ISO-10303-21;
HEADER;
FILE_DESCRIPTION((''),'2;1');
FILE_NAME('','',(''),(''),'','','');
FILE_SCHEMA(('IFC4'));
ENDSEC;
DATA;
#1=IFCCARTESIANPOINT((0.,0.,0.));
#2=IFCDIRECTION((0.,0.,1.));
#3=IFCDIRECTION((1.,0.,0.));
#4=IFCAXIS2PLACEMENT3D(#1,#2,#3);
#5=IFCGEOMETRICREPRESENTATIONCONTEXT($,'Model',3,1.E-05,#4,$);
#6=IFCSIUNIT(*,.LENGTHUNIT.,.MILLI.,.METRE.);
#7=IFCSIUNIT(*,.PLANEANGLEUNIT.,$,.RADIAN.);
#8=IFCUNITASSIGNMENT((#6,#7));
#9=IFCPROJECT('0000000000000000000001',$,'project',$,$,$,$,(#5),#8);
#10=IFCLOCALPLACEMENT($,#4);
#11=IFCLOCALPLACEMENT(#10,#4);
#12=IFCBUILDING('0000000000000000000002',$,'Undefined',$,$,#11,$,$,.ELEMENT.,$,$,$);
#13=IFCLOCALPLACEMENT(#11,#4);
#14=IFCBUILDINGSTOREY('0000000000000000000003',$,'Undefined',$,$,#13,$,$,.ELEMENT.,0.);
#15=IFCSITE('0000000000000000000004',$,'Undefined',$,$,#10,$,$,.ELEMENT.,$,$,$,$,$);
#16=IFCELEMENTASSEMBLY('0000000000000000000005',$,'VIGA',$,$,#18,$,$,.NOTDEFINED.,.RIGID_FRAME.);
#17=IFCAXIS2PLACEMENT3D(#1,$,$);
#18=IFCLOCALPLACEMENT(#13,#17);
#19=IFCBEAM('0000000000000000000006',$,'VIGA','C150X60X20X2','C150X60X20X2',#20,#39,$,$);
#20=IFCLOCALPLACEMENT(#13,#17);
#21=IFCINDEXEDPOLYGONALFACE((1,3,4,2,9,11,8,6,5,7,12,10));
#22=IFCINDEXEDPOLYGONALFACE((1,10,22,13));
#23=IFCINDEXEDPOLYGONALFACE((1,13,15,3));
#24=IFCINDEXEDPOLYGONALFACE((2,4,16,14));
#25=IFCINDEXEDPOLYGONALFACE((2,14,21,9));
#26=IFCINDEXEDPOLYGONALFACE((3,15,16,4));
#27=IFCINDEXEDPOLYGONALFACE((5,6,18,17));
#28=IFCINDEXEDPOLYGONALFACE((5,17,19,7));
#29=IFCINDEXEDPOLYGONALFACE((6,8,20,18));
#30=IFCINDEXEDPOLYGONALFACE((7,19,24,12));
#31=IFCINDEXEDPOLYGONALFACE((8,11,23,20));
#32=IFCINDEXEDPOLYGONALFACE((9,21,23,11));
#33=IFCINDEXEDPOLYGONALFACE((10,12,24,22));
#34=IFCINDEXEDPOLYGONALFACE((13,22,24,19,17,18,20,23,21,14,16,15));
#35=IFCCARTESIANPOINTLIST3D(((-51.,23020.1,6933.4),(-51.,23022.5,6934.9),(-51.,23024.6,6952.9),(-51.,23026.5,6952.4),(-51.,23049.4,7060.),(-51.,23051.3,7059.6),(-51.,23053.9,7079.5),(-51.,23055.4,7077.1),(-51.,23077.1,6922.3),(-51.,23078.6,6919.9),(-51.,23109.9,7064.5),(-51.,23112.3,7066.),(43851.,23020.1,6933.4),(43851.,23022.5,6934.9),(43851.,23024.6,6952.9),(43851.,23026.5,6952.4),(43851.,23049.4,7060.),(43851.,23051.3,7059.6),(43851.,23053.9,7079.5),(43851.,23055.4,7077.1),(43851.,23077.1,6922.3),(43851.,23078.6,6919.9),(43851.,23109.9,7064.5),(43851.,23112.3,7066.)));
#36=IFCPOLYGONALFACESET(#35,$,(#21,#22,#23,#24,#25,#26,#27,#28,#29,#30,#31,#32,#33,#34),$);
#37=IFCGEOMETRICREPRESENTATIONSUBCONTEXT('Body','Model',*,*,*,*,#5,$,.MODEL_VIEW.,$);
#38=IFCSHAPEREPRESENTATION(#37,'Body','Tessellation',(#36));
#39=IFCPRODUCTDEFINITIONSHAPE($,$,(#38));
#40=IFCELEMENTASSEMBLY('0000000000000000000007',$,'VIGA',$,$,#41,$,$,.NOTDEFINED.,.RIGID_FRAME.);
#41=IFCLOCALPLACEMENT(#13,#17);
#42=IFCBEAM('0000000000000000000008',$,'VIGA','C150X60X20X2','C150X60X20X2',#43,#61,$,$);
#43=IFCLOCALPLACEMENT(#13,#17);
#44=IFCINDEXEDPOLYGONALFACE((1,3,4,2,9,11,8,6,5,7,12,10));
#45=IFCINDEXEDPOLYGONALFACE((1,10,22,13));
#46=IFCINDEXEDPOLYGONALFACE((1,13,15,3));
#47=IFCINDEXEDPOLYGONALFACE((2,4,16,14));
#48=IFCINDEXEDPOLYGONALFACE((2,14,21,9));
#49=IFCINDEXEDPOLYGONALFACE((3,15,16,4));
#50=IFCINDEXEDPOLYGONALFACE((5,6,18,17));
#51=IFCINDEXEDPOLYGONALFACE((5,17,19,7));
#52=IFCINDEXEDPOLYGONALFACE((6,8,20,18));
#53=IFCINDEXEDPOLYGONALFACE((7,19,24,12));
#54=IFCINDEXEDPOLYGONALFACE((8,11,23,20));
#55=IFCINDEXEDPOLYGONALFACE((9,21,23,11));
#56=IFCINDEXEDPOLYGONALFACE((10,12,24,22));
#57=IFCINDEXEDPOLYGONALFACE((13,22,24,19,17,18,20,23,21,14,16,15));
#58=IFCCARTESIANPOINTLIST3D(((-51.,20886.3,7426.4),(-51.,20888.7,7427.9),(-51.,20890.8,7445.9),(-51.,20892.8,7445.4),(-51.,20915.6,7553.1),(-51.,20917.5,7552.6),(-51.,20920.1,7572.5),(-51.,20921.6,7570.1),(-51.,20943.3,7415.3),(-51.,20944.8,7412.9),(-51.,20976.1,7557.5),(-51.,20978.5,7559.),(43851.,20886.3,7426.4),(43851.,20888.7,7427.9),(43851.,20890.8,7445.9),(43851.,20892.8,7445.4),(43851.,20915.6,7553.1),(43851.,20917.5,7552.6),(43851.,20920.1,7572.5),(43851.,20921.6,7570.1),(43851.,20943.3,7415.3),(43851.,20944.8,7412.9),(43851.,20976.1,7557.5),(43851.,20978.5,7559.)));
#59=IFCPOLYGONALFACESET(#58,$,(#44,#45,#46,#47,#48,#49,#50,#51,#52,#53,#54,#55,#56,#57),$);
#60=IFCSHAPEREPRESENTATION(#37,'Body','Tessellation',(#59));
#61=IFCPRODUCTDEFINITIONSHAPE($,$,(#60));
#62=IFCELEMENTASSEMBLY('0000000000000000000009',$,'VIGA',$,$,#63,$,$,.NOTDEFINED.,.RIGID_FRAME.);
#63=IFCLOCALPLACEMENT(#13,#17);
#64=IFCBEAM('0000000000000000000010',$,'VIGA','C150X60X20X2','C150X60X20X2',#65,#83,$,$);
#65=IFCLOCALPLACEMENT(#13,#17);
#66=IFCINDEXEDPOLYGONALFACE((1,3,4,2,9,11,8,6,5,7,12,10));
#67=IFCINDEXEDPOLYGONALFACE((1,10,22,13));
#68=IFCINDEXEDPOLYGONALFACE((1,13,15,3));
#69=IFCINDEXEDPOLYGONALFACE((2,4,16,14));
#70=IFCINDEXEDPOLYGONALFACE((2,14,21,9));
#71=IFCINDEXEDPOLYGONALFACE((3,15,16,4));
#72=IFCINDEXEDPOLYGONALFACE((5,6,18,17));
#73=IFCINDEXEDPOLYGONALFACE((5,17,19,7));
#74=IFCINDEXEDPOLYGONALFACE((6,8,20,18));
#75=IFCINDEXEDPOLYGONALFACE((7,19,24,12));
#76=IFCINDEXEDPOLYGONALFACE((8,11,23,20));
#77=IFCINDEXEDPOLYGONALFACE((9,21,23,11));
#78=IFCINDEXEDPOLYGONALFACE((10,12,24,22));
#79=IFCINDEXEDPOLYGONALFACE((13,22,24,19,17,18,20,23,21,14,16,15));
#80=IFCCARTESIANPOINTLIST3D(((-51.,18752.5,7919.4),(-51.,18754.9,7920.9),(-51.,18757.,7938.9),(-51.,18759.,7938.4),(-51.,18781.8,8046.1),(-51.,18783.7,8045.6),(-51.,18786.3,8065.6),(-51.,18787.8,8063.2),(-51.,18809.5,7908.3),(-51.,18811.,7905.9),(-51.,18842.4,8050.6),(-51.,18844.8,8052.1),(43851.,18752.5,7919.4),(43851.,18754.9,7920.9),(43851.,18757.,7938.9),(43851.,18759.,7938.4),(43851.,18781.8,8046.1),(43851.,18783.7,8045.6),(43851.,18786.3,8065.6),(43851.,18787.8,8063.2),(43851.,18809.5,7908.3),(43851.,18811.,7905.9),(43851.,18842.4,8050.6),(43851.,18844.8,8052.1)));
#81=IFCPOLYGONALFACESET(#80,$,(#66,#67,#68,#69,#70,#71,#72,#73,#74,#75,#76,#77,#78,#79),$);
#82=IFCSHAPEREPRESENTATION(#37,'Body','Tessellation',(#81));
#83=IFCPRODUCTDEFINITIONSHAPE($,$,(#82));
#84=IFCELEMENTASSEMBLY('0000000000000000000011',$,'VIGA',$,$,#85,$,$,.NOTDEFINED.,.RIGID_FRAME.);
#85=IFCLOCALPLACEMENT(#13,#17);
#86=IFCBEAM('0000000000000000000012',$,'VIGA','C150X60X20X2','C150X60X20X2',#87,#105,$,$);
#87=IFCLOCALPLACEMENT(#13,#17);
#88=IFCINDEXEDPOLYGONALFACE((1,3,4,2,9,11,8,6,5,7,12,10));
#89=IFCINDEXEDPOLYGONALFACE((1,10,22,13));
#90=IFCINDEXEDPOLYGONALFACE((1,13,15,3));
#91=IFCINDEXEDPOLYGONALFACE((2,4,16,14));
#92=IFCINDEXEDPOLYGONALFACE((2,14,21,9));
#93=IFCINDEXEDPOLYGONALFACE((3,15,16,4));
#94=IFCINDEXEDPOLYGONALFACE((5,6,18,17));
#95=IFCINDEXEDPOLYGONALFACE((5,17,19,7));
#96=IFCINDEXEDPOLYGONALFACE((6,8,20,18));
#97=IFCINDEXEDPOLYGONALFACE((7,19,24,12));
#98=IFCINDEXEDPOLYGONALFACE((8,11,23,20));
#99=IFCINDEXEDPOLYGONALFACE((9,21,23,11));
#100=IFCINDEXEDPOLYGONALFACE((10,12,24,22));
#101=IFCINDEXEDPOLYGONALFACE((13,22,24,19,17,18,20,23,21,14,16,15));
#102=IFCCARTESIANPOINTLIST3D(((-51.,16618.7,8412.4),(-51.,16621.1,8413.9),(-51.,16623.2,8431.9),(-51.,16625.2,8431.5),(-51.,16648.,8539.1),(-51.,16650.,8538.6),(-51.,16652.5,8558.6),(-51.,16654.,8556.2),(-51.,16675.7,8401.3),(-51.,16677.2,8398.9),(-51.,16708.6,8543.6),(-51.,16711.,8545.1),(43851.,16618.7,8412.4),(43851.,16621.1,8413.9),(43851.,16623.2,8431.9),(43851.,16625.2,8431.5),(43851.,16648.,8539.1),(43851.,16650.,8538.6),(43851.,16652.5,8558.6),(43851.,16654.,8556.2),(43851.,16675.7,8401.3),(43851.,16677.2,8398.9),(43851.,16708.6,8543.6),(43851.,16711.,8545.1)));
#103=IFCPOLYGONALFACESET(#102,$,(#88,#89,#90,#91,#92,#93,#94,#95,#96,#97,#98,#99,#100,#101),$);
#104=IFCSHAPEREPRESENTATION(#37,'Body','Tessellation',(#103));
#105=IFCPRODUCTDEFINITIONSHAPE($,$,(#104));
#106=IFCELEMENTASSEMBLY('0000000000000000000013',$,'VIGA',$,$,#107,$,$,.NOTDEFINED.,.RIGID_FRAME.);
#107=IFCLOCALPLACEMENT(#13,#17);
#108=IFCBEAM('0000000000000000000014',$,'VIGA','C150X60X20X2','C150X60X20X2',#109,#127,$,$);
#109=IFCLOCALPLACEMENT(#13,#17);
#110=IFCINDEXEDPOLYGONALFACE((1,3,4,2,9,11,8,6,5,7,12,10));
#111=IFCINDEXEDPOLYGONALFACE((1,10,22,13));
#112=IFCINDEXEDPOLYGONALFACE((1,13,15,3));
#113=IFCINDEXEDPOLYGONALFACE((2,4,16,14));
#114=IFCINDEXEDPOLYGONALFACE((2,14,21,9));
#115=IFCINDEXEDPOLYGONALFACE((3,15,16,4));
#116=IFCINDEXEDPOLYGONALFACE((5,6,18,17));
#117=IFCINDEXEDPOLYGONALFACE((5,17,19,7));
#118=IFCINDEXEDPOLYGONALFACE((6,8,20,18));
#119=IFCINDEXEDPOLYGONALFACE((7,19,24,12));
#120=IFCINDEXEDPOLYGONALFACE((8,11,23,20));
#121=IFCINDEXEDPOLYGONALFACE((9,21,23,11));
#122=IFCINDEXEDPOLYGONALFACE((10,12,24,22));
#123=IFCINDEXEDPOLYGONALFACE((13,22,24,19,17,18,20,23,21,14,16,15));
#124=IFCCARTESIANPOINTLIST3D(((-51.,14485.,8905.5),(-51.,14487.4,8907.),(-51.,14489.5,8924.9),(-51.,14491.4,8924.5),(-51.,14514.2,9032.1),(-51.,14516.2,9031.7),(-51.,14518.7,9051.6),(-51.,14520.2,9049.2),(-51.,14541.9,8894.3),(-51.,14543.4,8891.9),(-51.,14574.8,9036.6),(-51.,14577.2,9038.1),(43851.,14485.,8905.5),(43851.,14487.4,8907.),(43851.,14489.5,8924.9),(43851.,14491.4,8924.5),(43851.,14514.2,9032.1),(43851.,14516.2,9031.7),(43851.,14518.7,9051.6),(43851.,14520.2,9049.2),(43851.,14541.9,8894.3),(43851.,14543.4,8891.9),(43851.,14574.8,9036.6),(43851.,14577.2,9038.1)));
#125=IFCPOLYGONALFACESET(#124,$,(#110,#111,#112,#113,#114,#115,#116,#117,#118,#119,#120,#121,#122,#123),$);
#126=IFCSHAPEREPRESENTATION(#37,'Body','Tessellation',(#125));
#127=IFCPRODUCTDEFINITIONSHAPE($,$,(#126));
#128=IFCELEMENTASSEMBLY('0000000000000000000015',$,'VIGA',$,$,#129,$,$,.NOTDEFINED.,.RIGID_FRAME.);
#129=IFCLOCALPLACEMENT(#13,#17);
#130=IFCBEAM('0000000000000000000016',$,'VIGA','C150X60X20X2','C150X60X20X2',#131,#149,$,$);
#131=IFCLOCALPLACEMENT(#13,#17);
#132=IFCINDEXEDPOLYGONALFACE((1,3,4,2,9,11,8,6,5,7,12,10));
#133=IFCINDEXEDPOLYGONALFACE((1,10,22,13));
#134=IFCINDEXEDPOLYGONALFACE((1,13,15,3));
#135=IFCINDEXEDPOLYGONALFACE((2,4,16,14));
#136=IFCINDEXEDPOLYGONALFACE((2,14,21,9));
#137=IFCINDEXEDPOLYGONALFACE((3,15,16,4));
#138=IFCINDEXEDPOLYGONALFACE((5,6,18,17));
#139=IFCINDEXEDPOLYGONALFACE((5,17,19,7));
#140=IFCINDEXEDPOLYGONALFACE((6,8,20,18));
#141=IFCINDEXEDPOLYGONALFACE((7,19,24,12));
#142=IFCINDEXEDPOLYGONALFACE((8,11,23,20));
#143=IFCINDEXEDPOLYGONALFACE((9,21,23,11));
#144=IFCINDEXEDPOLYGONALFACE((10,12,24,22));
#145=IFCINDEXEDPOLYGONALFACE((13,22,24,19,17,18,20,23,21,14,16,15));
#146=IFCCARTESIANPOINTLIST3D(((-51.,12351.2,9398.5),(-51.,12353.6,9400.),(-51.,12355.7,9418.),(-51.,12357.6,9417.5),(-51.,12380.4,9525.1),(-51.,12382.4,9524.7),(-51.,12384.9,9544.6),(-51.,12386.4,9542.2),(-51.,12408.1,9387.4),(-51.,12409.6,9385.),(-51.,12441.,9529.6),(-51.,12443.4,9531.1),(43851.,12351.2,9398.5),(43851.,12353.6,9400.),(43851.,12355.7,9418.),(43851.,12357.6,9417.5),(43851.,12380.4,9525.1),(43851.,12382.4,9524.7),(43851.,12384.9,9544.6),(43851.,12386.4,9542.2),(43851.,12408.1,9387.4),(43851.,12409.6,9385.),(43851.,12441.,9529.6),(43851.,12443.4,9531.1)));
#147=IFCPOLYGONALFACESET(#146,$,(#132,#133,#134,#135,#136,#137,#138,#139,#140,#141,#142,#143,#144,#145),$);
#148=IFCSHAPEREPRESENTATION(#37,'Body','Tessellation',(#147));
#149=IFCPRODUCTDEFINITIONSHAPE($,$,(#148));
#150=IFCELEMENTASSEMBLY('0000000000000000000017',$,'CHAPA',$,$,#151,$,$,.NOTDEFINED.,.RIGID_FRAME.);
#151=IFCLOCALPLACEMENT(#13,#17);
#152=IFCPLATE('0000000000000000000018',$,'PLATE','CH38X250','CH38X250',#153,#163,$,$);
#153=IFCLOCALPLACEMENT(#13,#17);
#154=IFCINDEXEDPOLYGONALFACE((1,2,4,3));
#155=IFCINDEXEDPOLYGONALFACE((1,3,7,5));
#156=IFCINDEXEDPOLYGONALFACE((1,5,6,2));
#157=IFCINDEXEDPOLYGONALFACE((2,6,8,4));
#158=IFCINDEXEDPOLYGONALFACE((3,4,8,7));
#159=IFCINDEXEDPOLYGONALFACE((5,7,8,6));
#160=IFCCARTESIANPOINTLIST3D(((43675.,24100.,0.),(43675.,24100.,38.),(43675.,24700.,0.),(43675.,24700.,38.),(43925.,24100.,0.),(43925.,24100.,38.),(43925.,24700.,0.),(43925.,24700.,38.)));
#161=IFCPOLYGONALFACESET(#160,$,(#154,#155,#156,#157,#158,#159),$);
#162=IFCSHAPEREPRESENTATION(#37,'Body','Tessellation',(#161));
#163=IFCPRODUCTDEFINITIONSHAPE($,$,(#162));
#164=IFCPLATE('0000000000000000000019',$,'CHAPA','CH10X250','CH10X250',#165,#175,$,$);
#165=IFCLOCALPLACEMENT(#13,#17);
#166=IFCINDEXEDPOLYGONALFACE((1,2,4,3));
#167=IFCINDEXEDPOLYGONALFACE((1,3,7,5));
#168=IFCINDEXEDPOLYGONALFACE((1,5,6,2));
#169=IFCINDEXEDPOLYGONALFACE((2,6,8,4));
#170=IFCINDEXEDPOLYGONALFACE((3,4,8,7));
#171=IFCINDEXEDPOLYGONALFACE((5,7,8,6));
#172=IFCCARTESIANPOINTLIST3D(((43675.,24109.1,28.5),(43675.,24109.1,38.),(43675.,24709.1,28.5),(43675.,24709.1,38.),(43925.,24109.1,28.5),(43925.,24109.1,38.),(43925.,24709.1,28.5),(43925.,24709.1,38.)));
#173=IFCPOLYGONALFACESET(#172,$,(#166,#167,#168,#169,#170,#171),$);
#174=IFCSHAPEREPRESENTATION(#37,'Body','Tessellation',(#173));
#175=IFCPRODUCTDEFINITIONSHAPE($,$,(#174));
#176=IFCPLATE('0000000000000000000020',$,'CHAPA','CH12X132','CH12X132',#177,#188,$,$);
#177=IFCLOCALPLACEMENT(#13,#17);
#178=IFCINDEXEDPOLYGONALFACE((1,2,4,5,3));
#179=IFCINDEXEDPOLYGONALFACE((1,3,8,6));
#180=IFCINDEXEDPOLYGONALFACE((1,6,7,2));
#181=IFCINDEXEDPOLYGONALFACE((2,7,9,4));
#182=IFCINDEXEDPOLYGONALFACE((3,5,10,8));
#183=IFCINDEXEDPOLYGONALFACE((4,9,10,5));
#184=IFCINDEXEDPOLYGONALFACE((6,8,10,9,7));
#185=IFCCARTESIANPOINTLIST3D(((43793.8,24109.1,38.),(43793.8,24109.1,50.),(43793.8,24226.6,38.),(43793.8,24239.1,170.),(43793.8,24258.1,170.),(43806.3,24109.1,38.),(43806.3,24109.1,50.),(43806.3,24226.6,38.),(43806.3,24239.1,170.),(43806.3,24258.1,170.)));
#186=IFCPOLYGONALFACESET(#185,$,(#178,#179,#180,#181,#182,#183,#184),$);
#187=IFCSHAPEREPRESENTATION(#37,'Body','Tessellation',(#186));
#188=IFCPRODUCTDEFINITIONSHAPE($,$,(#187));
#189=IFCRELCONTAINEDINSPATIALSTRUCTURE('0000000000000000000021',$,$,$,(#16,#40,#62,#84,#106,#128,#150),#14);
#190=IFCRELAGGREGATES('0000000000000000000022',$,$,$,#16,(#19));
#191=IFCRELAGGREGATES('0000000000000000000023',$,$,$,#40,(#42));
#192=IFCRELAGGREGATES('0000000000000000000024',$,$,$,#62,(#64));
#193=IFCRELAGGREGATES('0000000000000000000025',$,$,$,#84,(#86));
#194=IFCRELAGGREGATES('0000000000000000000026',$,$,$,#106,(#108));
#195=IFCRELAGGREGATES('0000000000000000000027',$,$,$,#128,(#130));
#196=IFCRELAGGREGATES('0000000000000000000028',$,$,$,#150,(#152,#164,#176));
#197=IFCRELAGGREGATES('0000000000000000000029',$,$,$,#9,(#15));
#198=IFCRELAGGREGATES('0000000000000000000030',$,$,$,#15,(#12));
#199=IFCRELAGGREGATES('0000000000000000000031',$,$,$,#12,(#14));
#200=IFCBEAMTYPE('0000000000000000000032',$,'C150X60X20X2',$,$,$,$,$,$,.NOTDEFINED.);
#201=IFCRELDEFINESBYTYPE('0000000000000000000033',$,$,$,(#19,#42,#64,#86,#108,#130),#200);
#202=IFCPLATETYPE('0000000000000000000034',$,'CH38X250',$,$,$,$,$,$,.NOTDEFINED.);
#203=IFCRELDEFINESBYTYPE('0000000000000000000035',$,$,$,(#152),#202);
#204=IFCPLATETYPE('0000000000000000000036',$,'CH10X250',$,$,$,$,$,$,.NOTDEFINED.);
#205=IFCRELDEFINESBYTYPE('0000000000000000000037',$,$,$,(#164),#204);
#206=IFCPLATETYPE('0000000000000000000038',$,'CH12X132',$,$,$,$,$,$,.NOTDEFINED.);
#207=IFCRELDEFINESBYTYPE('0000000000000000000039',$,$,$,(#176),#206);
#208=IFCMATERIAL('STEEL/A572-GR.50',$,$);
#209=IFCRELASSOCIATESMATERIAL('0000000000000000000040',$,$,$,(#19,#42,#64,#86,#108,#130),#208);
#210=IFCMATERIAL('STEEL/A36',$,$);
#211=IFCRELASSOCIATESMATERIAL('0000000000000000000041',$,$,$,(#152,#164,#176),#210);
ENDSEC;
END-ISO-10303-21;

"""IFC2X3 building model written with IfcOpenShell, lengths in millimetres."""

from ifc_helpers import new_model, si_unit, frame, origin_with_axes, origin_2d_with_axis, place, context, subcontext, project, spatial, polyline, c_section, outline, extrude, material, type_object, element, aggregate, save


model = new_model("IFC2X3")

# Units and contexts
model_context = context("Model", 3, precision=1e-05, world=origin_with_axes())
body_context = subcontext(model_context, "Body", "Model", "MODEL_VIEW")
ifc_project = project(units=[si_unit("LENGTHUNIT", "METRE", prefix="MILLI"), si_unit("PLANEANGLEUNIT", "RADIAN")], contexts=[model_context])

# Site, building, storey
site_placement = place(None, origin_with_axes())
site = spatial("IfcSite", under=ifc_project, at=site_placement, Name="Undefined", CompositionType="ELEMENT")
building_placement = place(site_placement, origin_with_axes())
building = spatial("IfcBuilding", under=site, at=building_placement, Name="Undefined", CompositionType="ELEMENT")
storey_placement = place(building_placement, origin_with_axes())
storey = spatial("IfcBuildingStorey", under=building, at=storey_placement, Name="Undefined", CompositionType="ELEMENT", Elevation=0.0)

# Element assemblies, beams
assembly_1_placement = place(storey_placement, origin_with_axes())
assembly_1 = element("IfcElementAssembly", 1, at=assembly_1_placement, inside=storey, Name="VIGA", AssemblyPlace="NOTDEFINED", PredefinedType="RIGID_FRAME")
ifc_material_1 = material(Name="STEEL/A572-GR.50")
beam_type = type_object("IfcBeamType", Name="C150X60X20X2", PredefinedType="NOTDEFINED")
beam_1_placement = place(assembly_1_placement, frame((43851.0, 23066.2, 6999.7), z_axis=(0.0, -0.225124, -0.97433), x_axis=(-1.0, 0.0, 0.0)))
beam_1 = element("IfcBeam", 2, at=beam_1_placement, type_object=beam_type, material=ifc_material_1, Name="VIGA", Description="C150X60X20X2", ObjectType="C150X60X20X2", context=body_context, shape_type="SweptSolid", body=[
    extrude(c_section(Depth=150.0, Width=60.0, WallThickness=2.0, Girth=20.0, at=origin_2d_with_axis()), frame((43902.0, 0.0, 0.0), z_axis=(-1.0, 0.0, 0.0), x_axis=(0.0, -1.0, 0.0)), (0.0, 0.0, 1.0), 43902.0),
])
assembly_2_placement = place(storey_placement, origin_with_axes())
assembly_2 = element("IfcElementAssembly", 3, at=assembly_2_placement, inside=storey, Name="VIGA", AssemblyPlace="NOTDEFINED", PredefinedType="RIGID_FRAME")
beam_2_placement = place(assembly_2_placement, frame((43851.0, 20932.4, 7492.7), z_axis=(0.0, -0.225124, -0.97433), x_axis=(-1.0, 0.0, 0.0)))
beam_2 = element("IfcBeam", 4, at=beam_2_placement, type_object=beam_type, material=ifc_material_1, Name="VIGA", Description="C150X60X20X2", ObjectType="C150X60X20X2", context=body_context, shape_type="SweptSolid", body=[
    extrude(c_section(Depth=150.0, Width=60.0, WallThickness=2.0, Girth=20.0, at=origin_2d_with_axis()), frame((43902.0, 0.0, 0.0), z_axis=(-1.0, 0.0, 0.0), x_axis=(0.0, -1.0, 0.0)), (0.0, 0.0, 1.0), 43902.0),
])
assembly_3_placement = place(storey_placement, origin_with_axes())
assembly_3 = element("IfcElementAssembly", 5, at=assembly_3_placement, inside=storey, Name="VIGA", AssemblyPlace="NOTDEFINED", PredefinedType="RIGID_FRAME")
beam_3_placement = place(assembly_3_placement, frame((43851.0, 18798.6, 7985.7), z_axis=(0.0, -0.225124, -0.97433), x_axis=(-1.0, 0.0, 0.0)))
beam_3 = element("IfcBeam", 6, at=beam_3_placement, type_object=beam_type, material=ifc_material_1, Name="VIGA", Description="C150X60X20X2", ObjectType="C150X60X20X2", context=body_context, shape_type="SweptSolid", body=[
    extrude(c_section(Depth=150.0, Width=60.0, WallThickness=2.0, Girth=20.0, at=origin_2d_with_axis()), frame((43902.0, 0.0, 0.0), z_axis=(-1.0, 0.0, 0.0), x_axis=(0.0, -1.0, 0.0)), (0.0, 0.0, 1.0), 43902.0),
])
assembly_4_placement = place(storey_placement, origin_with_axes())
assembly_4 = element("IfcElementAssembly", 7, at=assembly_4_placement, inside=storey, Name="VIGA", AssemblyPlace="NOTDEFINED", PredefinedType="RIGID_FRAME")
beam_4_placement = place(assembly_4_placement, frame((43851.0, 16664.9, 8478.8), z_axis=(0.0, -0.225124, -0.97433), x_axis=(-1.0, 0.0, 0.0)))
beam_4 = element("IfcBeam", 8, at=beam_4_placement, type_object=beam_type, material=ifc_material_1, Name="VIGA", Description="C150X60X20X2", ObjectType="C150X60X20X2", context=body_context, shape_type="SweptSolid", body=[
    extrude(c_section(Depth=150.0, Width=60.0, WallThickness=2.0, Girth=20.0, at=origin_2d_with_axis()), frame((43902.0, 0.0, 0.0), z_axis=(-1.0, 0.0, 0.0), x_axis=(0.0, -1.0, 0.0)), (0.0, 0.0, 1.0), 43902.0),
])
assembly_5_placement = place(storey_placement, origin_with_axes())
assembly_5 = element("IfcElementAssembly", 9, at=assembly_5_placement, inside=storey, Name="VIGA", AssemblyPlace="NOTDEFINED", PredefinedType="RIGID_FRAME")
beam_5_placement = place(assembly_5_placement, frame((43851.0, 14531.1, 8971.8), z_axis=(0.0, -0.225124, -0.97433), x_axis=(-1.0, 0.0, 0.0)))
beam_5 = element("IfcBeam", 10, at=beam_5_placement, type_object=beam_type, material=ifc_material_1, Name="VIGA", Description="C150X60X20X2", ObjectType="C150X60X20X2", context=body_context, shape_type="SweptSolid", body=[
    extrude(c_section(Depth=150.0, Width=60.0, WallThickness=2.0, Girth=20.0, at=origin_2d_with_axis()), frame((43902.0, 0.0, 0.0), z_axis=(-1.0, 0.0, 0.0), x_axis=(0.0, -1.0, 0.0)), (0.0, 0.0, 1.0), 43902.0),
])
assembly_6_placement = place(storey_placement, origin_with_axes())
assembly_6 = element("IfcElementAssembly", 11, at=assembly_6_placement, inside=storey, Name="VIGA", AssemblyPlace="NOTDEFINED", PredefinedType="RIGID_FRAME")
beam_6_placement = place(assembly_6_placement, frame((43851.0, 12397.3, 9464.8), z_axis=(0.0, -0.225124, -0.97433), x_axis=(-1.0, 0.0, 0.0)))
beam_6 = element("IfcBeam", 12, at=beam_6_placement, type_object=beam_type, material=ifc_material_1, Name="VIGA", Description="C150X60X20X2", ObjectType="C150X60X20X2", context=body_context, shape_type="SweptSolid", body=[
    extrude(c_section(Depth=150.0, Width=60.0, WallThickness=2.0, Girth=20.0, at=origin_2d_with_axis()), frame((43902.0, 0.0, 0.0), z_axis=(-1.0, 0.0, 0.0), x_axis=(0.0, -1.0, 0.0)), (0.0, 0.0, 1.0), 43902.0),
])

# Element assembly
assembly_7_placement = place(storey_placement, origin_with_axes())
assembly_7 = element("IfcElementAssembly", 13, at=assembly_7_placement, inside=storey, Name="CHAPA", AssemblyPlace="NOTDEFINED", PredefinedType="RIGID_FRAME")

# Plates
ifc_material_2 = material(Name="STEEL/A36")
plate_type_1 = type_object("IfcPlateType", Name="CH38X250", PredefinedType="NOTDEFINED")
plate_1_placement = place(assembly_7_placement, frame((43675.0, 24700.0, 19.0), z_axis=(0.0, 0.0, 1.0), x_axis=(0.0, -1.0, 0.0)))
plate_1 = element("IfcPlate", 14, at=plate_1_placement, type_object=plate_type_1, material=ifc_material_2, Name="PLATE", Description="CH38X250", ObjectType="CH38X250", context=body_context, shape_type="SweptSolid", body=[
    extrude(outline(polyline([(0.0, 0.0), (600.0, 0.0), (600.0, 250.0), (0.0, 250.0), (0.0, 0.0)])), frame((0.0, 0.0, -19.0), z_axis=(0.0, 0.0, 1.0), x_axis=(1.0, 0.0, 0.0)), (0.0, 0.0, 1.0), 38.0),
])
plate_type_2 = type_object("IfcPlateType", Name="CH10X250", PredefinedType="NOTDEFINED")
plate_2_placement = place(assembly_7_placement, frame((43675.0, 24709.1, 33.2), z_axis=(0.0, 0.0, -1.0), x_axis=(1.0, 0.0, 0.0)))
plate_2 = element("IfcPlate", 15, at=plate_2_placement, type_object=plate_type_2, material=ifc_material_2, Name="CHAPA", Description="CH10X250", ObjectType="CH10X250", context=body_context, shape_type="SweptSolid", body=[
    extrude(outline(polyline([(0.0, 0.0), (250.0, 0.0), (250.0, 600.0), (0.0, 600.0), (0.0, 0.0)])), frame((0.0, 0.0, -4.8), z_axis=(0.0, 0.0, 1.0), x_axis=(1.0, 0.0, 0.0)), (0.0, 0.0, 1.0), 9.5),
])
plate_type_3 = type_object("IfcPlateType", Name="CH12X132", PredefinedType="NOTDEFINED")
plate_3_placement = place(assembly_7_placement, frame((43800.0, 24226.6, 38.0), z_axis=(-1.0, 0.0, 0.0), x_axis=(0.0, -1.0, 0.0)))
plate_3 = element("IfcPlate", 16, at=plate_3_placement, type_object=plate_type_3, material=ifc_material_2, Name="CHAPA", Description="CH12X132", ObjectType="CH12X132", context=body_context, shape_type="SweptSolid", body=[
    extrude(outline(polyline([(0.0, 0.0), (117.5, 0.0), (117.5, 12.0), (-12.5, 132.0), (-31.6, 132.0), (0.0, 0.0)])), frame((0.0, 0.0, -6.2), z_axis=(0.0, 0.0, 1.0), x_axis=(1.0, 0.0, 0.0)), (0.0, 0.0, 1.0), 12.5),
])

aggregate(assembly_1, [beam_1])
aggregate(assembly_2, [beam_2])
aggregate(assembly_3, [beam_3])
aggregate(assembly_4, [beam_4])
aggregate(assembly_5, [beam_5])
aggregate(assembly_6, [beam_6])
aggregate(assembly_7, [plate_1, plate_2, plate_3])

save(model, "model.ifc")
